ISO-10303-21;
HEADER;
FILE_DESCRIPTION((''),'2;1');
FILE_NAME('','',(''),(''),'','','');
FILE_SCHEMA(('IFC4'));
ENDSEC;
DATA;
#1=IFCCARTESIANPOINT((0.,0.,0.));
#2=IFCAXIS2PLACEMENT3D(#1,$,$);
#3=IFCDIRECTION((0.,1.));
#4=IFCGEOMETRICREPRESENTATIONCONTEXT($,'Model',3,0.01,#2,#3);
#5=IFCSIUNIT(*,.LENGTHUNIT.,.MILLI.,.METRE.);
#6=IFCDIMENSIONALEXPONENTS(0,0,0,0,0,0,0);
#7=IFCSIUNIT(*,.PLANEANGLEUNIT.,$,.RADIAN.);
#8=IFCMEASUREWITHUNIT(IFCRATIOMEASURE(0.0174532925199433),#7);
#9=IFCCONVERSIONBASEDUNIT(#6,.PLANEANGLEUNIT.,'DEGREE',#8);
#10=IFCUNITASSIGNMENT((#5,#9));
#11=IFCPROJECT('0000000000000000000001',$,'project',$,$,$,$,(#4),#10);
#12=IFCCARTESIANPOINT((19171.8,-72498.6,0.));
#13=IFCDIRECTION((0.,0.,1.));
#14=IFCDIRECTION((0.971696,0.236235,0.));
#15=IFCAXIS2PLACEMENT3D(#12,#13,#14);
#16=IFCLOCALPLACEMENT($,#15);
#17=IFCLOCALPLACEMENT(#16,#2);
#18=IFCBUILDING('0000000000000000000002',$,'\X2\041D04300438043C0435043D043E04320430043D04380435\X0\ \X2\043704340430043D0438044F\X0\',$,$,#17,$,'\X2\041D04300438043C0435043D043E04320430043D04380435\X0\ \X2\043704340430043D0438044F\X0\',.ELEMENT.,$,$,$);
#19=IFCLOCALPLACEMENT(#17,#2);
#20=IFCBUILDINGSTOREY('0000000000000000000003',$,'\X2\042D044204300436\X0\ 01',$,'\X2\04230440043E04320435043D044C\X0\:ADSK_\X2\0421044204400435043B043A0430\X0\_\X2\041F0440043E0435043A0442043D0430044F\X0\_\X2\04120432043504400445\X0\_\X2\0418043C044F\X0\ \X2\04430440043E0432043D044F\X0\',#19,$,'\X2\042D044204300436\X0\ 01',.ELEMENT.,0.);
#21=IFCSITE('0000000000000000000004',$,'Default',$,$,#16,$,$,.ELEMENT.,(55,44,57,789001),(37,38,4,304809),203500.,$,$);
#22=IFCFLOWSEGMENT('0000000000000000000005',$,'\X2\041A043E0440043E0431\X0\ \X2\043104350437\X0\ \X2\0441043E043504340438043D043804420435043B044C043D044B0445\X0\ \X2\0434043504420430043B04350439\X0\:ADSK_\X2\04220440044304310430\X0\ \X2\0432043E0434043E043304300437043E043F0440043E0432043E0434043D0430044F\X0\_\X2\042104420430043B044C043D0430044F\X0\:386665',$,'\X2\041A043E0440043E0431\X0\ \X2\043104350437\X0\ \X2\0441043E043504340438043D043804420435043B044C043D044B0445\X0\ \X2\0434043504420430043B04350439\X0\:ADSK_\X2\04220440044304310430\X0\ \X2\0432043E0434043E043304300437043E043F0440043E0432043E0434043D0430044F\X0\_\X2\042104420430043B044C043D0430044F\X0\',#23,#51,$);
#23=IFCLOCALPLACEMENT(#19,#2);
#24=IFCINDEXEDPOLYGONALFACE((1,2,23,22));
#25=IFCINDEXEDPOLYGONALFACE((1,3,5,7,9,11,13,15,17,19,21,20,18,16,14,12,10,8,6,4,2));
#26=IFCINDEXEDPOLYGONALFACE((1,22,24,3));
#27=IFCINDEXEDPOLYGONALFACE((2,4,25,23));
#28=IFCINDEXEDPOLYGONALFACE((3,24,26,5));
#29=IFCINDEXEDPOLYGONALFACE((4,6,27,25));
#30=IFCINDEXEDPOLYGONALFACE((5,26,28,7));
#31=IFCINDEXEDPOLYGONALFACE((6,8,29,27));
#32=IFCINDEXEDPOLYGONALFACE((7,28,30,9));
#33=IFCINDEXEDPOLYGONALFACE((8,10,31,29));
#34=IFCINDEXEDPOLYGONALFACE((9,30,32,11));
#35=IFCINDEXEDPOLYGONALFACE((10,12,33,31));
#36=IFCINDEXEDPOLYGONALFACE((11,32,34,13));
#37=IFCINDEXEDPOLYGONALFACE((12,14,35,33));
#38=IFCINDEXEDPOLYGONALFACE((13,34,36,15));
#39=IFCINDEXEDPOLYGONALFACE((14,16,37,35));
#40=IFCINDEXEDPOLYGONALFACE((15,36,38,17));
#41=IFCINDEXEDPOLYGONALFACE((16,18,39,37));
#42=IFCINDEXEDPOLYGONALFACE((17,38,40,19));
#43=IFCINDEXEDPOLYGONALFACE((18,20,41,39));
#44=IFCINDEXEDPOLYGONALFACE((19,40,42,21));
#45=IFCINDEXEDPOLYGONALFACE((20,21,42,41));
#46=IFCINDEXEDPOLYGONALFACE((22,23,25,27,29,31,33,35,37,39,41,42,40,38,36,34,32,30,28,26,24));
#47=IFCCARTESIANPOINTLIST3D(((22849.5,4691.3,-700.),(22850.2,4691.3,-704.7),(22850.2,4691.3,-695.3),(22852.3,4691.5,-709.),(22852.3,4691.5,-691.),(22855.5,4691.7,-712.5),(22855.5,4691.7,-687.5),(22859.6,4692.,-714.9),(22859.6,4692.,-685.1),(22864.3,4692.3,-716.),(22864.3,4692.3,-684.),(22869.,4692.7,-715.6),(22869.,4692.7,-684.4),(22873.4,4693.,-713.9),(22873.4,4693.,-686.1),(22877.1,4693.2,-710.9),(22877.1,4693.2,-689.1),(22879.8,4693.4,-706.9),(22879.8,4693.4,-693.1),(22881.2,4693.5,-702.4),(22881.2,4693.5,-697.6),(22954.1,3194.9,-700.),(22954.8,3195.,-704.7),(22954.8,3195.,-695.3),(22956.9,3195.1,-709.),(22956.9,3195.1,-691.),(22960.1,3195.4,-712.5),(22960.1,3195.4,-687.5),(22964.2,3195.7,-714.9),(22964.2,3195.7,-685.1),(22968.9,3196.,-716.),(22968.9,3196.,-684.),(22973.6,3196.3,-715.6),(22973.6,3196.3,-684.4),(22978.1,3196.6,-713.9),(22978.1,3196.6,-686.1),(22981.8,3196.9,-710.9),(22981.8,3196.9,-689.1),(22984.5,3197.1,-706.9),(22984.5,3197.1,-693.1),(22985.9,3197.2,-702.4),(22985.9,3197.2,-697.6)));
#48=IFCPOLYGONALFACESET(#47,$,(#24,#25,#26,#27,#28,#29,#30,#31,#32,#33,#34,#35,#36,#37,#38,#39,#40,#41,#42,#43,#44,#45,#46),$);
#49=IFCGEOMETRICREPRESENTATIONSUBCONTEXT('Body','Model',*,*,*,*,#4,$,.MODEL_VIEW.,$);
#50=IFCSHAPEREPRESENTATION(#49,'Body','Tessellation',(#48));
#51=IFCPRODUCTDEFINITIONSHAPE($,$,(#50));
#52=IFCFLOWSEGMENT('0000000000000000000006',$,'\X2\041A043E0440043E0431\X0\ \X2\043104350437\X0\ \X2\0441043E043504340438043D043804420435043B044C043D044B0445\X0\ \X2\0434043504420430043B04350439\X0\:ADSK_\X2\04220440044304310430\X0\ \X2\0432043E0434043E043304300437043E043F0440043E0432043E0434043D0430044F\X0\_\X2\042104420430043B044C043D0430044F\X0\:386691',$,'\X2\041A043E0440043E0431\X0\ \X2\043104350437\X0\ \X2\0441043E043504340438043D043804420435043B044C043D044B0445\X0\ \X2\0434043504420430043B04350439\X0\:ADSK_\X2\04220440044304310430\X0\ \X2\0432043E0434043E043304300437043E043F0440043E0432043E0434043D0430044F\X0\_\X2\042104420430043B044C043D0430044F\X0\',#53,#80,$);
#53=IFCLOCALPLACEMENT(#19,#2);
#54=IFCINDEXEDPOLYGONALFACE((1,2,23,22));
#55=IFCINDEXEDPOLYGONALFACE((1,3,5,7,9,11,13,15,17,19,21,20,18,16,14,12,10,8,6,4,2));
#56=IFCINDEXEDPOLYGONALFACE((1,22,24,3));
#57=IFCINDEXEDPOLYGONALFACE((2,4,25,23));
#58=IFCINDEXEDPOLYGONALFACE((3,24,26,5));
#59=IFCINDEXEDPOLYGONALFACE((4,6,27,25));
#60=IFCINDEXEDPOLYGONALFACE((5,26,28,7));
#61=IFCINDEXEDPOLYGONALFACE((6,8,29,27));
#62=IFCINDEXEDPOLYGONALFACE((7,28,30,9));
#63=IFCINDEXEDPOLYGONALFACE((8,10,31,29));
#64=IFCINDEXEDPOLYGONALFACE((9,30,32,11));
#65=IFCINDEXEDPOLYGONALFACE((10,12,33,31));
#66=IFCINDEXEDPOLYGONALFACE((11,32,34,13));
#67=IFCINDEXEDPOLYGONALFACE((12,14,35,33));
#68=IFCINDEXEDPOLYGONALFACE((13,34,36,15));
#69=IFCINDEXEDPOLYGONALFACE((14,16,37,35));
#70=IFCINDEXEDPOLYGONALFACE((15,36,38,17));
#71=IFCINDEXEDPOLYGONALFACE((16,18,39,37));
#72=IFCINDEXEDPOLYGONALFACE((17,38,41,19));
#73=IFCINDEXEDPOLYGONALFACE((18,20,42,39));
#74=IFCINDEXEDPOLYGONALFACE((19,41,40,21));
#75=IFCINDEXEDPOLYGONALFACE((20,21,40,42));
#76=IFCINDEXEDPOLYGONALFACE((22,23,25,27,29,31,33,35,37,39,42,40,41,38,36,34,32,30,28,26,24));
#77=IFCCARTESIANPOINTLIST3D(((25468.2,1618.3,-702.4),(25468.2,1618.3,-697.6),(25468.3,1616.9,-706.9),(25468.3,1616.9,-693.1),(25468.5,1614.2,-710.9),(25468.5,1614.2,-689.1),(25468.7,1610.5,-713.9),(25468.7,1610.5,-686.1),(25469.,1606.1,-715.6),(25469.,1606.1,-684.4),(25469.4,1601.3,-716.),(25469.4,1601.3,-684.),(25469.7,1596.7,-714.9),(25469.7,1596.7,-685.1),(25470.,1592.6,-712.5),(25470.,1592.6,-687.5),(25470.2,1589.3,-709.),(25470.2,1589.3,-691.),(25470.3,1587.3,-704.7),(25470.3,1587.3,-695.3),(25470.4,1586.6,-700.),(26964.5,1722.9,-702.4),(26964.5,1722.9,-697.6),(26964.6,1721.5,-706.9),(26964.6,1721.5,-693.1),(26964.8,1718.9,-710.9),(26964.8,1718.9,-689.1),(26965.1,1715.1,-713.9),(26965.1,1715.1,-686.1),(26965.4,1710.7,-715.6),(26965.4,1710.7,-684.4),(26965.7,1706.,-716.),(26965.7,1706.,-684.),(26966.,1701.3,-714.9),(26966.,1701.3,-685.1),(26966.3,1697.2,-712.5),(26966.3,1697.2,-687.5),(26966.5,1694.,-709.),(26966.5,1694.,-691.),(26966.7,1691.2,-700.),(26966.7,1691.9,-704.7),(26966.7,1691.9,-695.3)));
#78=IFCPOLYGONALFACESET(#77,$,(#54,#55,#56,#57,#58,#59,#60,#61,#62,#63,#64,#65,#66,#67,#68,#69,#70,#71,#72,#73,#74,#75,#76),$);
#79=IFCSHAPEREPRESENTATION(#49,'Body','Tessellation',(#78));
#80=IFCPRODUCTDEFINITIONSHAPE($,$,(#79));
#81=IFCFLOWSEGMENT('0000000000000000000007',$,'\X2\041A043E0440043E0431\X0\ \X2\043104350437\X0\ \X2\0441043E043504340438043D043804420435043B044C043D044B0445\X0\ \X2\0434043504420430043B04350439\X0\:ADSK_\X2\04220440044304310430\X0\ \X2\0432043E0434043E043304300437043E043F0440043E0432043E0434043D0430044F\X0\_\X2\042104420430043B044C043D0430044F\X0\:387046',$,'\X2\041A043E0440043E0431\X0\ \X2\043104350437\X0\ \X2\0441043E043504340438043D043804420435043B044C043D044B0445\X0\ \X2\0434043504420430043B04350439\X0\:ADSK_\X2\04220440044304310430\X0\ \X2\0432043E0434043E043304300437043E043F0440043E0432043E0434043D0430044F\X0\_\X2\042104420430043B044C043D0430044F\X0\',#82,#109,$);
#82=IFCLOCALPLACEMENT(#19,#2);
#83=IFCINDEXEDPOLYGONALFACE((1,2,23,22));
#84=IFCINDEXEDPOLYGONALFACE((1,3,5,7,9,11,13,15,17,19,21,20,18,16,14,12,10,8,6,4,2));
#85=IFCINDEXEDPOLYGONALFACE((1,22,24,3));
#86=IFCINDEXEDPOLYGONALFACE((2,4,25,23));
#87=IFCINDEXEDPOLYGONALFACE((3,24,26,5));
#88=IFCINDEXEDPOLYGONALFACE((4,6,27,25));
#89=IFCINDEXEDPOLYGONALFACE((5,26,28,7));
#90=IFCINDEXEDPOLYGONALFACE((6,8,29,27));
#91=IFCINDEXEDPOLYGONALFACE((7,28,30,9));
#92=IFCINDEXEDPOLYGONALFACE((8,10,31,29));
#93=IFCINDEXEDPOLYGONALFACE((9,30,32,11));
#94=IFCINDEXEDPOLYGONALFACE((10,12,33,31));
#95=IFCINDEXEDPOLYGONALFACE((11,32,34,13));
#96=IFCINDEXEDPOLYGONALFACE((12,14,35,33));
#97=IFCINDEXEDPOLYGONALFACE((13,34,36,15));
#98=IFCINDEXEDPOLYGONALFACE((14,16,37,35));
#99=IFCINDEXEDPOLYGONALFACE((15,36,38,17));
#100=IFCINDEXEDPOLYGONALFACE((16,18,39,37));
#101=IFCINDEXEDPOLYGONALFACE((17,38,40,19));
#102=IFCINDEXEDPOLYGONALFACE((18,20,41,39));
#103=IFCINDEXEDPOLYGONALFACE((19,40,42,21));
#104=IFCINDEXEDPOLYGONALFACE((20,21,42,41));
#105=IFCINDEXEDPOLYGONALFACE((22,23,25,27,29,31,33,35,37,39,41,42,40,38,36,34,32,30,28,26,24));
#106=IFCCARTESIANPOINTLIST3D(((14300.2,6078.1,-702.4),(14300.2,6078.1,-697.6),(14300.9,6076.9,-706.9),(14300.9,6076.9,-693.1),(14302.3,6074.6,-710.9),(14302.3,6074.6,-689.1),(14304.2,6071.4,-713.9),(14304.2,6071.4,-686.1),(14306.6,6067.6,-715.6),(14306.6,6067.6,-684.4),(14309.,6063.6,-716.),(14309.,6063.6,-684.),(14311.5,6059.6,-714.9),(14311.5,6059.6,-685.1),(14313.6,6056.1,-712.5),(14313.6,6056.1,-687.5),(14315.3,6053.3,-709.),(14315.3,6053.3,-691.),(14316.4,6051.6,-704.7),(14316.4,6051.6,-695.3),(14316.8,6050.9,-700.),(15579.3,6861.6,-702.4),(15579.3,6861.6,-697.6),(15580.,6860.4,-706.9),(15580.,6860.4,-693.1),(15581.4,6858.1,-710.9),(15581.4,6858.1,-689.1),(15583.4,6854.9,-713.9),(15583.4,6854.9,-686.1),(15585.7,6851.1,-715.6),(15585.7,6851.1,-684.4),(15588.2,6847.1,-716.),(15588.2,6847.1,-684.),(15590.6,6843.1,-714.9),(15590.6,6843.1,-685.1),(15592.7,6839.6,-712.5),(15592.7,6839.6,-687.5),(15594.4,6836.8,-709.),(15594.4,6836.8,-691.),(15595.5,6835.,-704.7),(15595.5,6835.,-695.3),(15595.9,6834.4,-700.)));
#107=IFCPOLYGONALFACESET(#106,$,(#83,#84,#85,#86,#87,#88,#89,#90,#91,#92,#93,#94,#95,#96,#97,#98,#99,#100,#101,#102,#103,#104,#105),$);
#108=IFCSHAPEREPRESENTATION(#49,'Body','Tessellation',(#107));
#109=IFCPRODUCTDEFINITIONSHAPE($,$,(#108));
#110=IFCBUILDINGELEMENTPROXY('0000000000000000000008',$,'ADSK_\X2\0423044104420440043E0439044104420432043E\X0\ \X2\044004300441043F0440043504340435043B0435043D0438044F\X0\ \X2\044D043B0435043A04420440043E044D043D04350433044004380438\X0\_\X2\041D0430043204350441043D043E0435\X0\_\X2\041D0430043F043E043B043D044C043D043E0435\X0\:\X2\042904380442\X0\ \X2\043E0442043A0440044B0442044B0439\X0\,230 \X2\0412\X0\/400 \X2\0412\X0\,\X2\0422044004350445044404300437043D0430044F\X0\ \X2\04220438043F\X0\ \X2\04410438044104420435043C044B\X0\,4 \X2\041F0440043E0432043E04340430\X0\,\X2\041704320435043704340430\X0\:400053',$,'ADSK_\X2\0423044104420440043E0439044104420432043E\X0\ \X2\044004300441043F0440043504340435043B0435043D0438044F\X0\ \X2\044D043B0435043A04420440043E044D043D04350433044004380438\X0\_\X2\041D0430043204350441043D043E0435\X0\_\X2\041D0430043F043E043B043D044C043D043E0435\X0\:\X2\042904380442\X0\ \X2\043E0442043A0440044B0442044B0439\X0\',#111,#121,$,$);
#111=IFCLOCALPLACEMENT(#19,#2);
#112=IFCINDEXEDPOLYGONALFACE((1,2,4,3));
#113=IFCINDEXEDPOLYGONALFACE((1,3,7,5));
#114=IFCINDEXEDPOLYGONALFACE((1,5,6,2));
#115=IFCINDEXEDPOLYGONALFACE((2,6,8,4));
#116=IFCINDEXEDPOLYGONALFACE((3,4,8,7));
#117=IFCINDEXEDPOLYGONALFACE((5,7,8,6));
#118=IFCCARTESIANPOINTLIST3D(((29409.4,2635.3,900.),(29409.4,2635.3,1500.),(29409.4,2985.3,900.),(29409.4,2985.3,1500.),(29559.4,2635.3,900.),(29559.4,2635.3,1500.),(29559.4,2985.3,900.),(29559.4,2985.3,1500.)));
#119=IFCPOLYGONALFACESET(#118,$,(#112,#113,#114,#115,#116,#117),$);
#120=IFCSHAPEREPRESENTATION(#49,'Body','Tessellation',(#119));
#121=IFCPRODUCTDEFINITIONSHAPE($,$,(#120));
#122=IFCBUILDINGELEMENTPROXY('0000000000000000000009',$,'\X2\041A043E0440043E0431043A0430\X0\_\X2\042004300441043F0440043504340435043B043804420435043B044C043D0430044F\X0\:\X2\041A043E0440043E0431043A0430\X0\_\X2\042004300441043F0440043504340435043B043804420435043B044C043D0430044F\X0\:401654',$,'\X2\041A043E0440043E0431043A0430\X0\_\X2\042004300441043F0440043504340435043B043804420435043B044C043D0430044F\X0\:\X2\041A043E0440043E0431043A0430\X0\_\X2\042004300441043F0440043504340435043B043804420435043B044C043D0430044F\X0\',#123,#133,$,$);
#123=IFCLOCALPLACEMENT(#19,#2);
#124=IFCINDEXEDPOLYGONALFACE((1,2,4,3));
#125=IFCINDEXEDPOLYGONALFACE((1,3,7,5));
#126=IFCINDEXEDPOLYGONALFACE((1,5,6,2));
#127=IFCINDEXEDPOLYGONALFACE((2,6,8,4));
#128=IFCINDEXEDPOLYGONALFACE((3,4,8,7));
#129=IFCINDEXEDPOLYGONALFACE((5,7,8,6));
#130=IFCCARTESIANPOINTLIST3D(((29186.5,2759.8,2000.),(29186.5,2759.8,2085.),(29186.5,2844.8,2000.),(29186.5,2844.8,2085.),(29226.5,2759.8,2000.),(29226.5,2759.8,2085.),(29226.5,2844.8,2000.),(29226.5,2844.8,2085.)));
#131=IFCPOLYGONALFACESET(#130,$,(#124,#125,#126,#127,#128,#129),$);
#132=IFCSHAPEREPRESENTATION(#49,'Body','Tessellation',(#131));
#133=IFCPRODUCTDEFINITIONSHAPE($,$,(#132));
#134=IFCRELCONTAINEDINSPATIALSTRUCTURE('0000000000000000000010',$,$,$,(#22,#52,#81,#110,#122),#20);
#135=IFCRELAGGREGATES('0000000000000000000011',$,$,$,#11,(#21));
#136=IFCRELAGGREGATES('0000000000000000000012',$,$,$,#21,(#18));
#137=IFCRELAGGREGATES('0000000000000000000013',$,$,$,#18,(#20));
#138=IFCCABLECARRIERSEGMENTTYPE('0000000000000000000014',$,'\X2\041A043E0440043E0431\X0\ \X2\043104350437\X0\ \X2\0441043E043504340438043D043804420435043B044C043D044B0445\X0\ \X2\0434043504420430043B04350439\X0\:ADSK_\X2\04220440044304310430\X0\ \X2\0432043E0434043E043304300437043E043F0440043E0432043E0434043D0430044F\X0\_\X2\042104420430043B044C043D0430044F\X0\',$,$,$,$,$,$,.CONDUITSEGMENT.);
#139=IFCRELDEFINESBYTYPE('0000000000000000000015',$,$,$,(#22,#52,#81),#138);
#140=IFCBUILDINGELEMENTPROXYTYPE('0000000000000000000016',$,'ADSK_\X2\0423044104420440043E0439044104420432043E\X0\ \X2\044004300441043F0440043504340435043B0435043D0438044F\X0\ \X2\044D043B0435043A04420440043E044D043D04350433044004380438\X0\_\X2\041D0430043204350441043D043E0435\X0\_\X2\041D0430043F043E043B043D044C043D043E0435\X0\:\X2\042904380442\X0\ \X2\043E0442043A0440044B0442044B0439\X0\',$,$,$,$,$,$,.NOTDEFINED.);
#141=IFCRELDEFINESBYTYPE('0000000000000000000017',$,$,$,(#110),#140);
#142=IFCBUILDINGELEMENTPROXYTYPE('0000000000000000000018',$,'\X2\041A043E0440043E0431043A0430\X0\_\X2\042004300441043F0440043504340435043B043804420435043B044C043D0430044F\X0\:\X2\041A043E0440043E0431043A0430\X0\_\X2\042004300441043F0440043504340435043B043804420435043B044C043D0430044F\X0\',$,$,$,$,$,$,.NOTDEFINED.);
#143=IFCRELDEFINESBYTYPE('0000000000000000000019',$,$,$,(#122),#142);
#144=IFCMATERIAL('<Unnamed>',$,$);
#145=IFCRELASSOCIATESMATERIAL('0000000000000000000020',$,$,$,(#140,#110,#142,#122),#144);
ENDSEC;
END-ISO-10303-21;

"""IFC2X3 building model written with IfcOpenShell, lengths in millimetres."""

from ifc_helpers import new_model, entity, si_unit, converted_unit, direction, frame, origin, origin_2d_with_axis, place, context, subcontext, project, spatial, rectangle, circle, extrude, source, transform, mapped, material, type_object, type_shapes, element, save


model = new_model("IFC2X3")

# Units and contexts
model_context = context("Model", 3, precision=0.01, world=origin(), true_north=direction((0.0, 1.0)))
body_context = subcontext(model_context, "Body", "Model", "MODEL_VIEW")
ifc_project = project(units=[si_unit("LENGTHUNIT", "METRE", prefix="MILLI"), converted_unit("PLANEANGLEUNIT", "DEGREE", entity("IfcRatioMeasure", 0.0174532925199433), si_unit("PLANEANGLEUNIT", "RADIAN"), dimensions=[0, 0, 0, 0, 0, 0, 0])], contexts=[model_context])

# Site, building, storey
site_placement = place(None, frame((19171.8, -72498.6, 0.0), z_axis=(0.0, 0.0, 1.0), x_axis=(0.971696, 0.236235, 0.0)))
site = spatial("IfcSite", under=ifc_project, at=site_placement, Name="Default", CompositionType="ELEMENT", RefLatitude=(55, 44, 57, 789001), RefLongitude=(37, 38, 4, 304809), RefElevation=203500.0)
building_placement = place(site_placement, origin())
building = spatial("IfcBuilding", under=site, at=building_placement, Name="Наименование здания", LongName="Наименование здания", CompositionType="ELEMENT")
storey_placement = place(building_placement, origin())
storey = spatial("IfcBuildingStorey", under=building, at=storey_placement, Name="Этаж 01", ObjectType="Уровень:ADSK_Стрелка_Проектная_Вверх_Имя уровня", LongName="Этаж 01", CompositionType="ELEMENT", Elevation=0.0)

# Shared definitions
ifc_material = material(Name="<Unnamed>")

# Flow segments
cable_carrier_segment_type_1 = type_object("IfcCableCarrierSegmentType", Name="Короб без соединительных деталей:ADSK_Труба водогазопроводная_Стальная", PredefinedType="CONDUITSEGMENT")
flow_segment_1_placement = place(storey_placement, frame((22847.9, 3193.3, -717.6)))
element("IfcFlowSegment", 1, at=flow_segment_1_placement, inside=storey, type_object=cable_carrier_segment_type_1, Name="Короб без соединительных деталей:ADSK_Труба водогазопроводная_Стальная:386665", ObjectType="Короб без соединительных деталей:ADSK_Труба водогазопроводная_Стальная", context=body_context, shape_type="SweptSolid", body=[
    extrude(circle(Radius=16.0, at=origin_2d_with_axis()), frame((122.2, 2.7, 17.6), z_axis=(-0.069756, 0.997564, 0.0), x_axis=(-0.997564, -0.069756, 0.0)), (0.0, 0.0, 1.0), 1500.0),
])
flow_segment_2_placement = place(storey_placement, frame((25466.6, 1585.0, -717.6)))
element("IfcFlowSegment", 2, at=flow_segment_2_placement, inside=storey, type_object=cable_carrier_segment_type_1, Name="Короб без соединительных деталей:ADSK_Труба водогазопроводная_Стальная:386691", ObjectType="Короб без соединительных деталей:ADSK_Труба водогазопроводная_Стальная", context=body_context, shape_type="SweptSolid", body=[
    extrude(circle(Radius=16.0, at=origin_2d_with_axis()), frame((2.7, 17.6, 17.6), z_axis=(0.997564, 0.069756, 0.0), x_axis=(0.069756, -0.997564, 0.0)), (0.0, 0.0, 1.0), 1500.0),
])
flow_segment_3_placement = place(storey_placement, frame((14298.5, 6049.4, -717.6)))
element("IfcFlowSegment", 3, at=flow_segment_3_placement, inside=storey, type_object=cable_carrier_segment_type_1, Name="Короб без соединительных деталей:ADSK_Труба водогазопроводная_Стальная:387046", ObjectType="Короб без соединительных деталей:ADSK_Труба водогазопроводная_Стальная", context=body_context, shape_type="SweptSolid", body=[
    extrude(circle(Radius=16.0, at=origin_2d_with_axis()), frame((9.9, 15.2, 17.6), z_axis=(0.852745, 0.522328, 0.0), x_axis=(0.522328, -0.852745, 0.0)), (0.0, 0.0, 1.0), 1500.0),
])

# Building element proxies
building_element_proxy_type_1 = type_object("IfcBuildingElementProxyType", Name="ADSK_Устройство распределения электроэнегрии_Навесное_Наполньное:Щит открытый", PredefinedType="NOTDEFINED", material=ifc_material)
shared_shape_1 = source(origin(), body_context, "Body", "SweptSolid", [
    extrude(rectangle(XDim=350.0, YDim=150.0, at=origin_2d_with_axis()), frame((0.0, 75.0, -600.0), z_axis=(0.0, 0.0, 1.0), x_axis=(-1.0, 0.0, 0.0)), (0.0, 0.0, 1.0), 600.0),
])
type_shapes(building_element_proxy_type_1, [shared_shape_1])
proxy_1_placement = place(storey_placement, frame((29559.4, 2810.3, 1500.0), z_axis=(0.0, 0.0, 1.0), x_axis=(0.0, 1.0, 0.0)))
element("IfcBuildingElementProxy", 4, at=proxy_1_placement, inside=storey, type_object=building_element_proxy_type_1, material=ifc_material, Name="ADSK_Устройство распределения электроэнегрии_Навесное_Наполньное:Щит открытый,230 В/400 В,Трехфазная Тип системы,4 Провода,Звезда:400053", ObjectType="ADSK_Устройство распределения электроэнегрии_Навесное_Наполньное:Щит открытый", context=body_context, shape_type="MappedRepresentation", body=[
    mapped(shared_shape_1, transform((0.0, 0.0, 0.0), scale=1.0)),
])
building_element_proxy_type_2 = type_object("IfcBuildingElementProxyType", Name="Коробка_Распределительная:Коробка_Распределительная", PredefinedType="NOTDEFINED", material=ifc_material)
shared_shape_2 = source(origin(), body_context, "Body", "SweptSolid", [
    extrude(rectangle(XDim=85.0, YDim=40.0, at=origin_2d_with_axis()), origin(), (0.0, 0.0, 1.0), 85.0),
])
type_shapes(building_element_proxy_type_2, [shared_shape_2])
proxy_2_placement = place(storey_placement, frame((29206.5, 2802.2, 2000.0), z_axis=(0.0, 0.0, 1.0), x_axis=(0.0, 1.0, 0.0)))
element("IfcBuildingElementProxy", 5, at=proxy_2_placement, inside=storey, type_object=building_element_proxy_type_2, material=ifc_material, Name="Коробка_Распределительная:Коробка_Распределительная:401654", ObjectType="Коробка_Распределительная:Коробка_Распределительная", context=body_context, shape_type="MappedRepresentation", body=[
    mapped(shared_shape_2, transform((0.0, 0.0, 0.0), scale=1.0)),
])

save(model, "model.ifc")
